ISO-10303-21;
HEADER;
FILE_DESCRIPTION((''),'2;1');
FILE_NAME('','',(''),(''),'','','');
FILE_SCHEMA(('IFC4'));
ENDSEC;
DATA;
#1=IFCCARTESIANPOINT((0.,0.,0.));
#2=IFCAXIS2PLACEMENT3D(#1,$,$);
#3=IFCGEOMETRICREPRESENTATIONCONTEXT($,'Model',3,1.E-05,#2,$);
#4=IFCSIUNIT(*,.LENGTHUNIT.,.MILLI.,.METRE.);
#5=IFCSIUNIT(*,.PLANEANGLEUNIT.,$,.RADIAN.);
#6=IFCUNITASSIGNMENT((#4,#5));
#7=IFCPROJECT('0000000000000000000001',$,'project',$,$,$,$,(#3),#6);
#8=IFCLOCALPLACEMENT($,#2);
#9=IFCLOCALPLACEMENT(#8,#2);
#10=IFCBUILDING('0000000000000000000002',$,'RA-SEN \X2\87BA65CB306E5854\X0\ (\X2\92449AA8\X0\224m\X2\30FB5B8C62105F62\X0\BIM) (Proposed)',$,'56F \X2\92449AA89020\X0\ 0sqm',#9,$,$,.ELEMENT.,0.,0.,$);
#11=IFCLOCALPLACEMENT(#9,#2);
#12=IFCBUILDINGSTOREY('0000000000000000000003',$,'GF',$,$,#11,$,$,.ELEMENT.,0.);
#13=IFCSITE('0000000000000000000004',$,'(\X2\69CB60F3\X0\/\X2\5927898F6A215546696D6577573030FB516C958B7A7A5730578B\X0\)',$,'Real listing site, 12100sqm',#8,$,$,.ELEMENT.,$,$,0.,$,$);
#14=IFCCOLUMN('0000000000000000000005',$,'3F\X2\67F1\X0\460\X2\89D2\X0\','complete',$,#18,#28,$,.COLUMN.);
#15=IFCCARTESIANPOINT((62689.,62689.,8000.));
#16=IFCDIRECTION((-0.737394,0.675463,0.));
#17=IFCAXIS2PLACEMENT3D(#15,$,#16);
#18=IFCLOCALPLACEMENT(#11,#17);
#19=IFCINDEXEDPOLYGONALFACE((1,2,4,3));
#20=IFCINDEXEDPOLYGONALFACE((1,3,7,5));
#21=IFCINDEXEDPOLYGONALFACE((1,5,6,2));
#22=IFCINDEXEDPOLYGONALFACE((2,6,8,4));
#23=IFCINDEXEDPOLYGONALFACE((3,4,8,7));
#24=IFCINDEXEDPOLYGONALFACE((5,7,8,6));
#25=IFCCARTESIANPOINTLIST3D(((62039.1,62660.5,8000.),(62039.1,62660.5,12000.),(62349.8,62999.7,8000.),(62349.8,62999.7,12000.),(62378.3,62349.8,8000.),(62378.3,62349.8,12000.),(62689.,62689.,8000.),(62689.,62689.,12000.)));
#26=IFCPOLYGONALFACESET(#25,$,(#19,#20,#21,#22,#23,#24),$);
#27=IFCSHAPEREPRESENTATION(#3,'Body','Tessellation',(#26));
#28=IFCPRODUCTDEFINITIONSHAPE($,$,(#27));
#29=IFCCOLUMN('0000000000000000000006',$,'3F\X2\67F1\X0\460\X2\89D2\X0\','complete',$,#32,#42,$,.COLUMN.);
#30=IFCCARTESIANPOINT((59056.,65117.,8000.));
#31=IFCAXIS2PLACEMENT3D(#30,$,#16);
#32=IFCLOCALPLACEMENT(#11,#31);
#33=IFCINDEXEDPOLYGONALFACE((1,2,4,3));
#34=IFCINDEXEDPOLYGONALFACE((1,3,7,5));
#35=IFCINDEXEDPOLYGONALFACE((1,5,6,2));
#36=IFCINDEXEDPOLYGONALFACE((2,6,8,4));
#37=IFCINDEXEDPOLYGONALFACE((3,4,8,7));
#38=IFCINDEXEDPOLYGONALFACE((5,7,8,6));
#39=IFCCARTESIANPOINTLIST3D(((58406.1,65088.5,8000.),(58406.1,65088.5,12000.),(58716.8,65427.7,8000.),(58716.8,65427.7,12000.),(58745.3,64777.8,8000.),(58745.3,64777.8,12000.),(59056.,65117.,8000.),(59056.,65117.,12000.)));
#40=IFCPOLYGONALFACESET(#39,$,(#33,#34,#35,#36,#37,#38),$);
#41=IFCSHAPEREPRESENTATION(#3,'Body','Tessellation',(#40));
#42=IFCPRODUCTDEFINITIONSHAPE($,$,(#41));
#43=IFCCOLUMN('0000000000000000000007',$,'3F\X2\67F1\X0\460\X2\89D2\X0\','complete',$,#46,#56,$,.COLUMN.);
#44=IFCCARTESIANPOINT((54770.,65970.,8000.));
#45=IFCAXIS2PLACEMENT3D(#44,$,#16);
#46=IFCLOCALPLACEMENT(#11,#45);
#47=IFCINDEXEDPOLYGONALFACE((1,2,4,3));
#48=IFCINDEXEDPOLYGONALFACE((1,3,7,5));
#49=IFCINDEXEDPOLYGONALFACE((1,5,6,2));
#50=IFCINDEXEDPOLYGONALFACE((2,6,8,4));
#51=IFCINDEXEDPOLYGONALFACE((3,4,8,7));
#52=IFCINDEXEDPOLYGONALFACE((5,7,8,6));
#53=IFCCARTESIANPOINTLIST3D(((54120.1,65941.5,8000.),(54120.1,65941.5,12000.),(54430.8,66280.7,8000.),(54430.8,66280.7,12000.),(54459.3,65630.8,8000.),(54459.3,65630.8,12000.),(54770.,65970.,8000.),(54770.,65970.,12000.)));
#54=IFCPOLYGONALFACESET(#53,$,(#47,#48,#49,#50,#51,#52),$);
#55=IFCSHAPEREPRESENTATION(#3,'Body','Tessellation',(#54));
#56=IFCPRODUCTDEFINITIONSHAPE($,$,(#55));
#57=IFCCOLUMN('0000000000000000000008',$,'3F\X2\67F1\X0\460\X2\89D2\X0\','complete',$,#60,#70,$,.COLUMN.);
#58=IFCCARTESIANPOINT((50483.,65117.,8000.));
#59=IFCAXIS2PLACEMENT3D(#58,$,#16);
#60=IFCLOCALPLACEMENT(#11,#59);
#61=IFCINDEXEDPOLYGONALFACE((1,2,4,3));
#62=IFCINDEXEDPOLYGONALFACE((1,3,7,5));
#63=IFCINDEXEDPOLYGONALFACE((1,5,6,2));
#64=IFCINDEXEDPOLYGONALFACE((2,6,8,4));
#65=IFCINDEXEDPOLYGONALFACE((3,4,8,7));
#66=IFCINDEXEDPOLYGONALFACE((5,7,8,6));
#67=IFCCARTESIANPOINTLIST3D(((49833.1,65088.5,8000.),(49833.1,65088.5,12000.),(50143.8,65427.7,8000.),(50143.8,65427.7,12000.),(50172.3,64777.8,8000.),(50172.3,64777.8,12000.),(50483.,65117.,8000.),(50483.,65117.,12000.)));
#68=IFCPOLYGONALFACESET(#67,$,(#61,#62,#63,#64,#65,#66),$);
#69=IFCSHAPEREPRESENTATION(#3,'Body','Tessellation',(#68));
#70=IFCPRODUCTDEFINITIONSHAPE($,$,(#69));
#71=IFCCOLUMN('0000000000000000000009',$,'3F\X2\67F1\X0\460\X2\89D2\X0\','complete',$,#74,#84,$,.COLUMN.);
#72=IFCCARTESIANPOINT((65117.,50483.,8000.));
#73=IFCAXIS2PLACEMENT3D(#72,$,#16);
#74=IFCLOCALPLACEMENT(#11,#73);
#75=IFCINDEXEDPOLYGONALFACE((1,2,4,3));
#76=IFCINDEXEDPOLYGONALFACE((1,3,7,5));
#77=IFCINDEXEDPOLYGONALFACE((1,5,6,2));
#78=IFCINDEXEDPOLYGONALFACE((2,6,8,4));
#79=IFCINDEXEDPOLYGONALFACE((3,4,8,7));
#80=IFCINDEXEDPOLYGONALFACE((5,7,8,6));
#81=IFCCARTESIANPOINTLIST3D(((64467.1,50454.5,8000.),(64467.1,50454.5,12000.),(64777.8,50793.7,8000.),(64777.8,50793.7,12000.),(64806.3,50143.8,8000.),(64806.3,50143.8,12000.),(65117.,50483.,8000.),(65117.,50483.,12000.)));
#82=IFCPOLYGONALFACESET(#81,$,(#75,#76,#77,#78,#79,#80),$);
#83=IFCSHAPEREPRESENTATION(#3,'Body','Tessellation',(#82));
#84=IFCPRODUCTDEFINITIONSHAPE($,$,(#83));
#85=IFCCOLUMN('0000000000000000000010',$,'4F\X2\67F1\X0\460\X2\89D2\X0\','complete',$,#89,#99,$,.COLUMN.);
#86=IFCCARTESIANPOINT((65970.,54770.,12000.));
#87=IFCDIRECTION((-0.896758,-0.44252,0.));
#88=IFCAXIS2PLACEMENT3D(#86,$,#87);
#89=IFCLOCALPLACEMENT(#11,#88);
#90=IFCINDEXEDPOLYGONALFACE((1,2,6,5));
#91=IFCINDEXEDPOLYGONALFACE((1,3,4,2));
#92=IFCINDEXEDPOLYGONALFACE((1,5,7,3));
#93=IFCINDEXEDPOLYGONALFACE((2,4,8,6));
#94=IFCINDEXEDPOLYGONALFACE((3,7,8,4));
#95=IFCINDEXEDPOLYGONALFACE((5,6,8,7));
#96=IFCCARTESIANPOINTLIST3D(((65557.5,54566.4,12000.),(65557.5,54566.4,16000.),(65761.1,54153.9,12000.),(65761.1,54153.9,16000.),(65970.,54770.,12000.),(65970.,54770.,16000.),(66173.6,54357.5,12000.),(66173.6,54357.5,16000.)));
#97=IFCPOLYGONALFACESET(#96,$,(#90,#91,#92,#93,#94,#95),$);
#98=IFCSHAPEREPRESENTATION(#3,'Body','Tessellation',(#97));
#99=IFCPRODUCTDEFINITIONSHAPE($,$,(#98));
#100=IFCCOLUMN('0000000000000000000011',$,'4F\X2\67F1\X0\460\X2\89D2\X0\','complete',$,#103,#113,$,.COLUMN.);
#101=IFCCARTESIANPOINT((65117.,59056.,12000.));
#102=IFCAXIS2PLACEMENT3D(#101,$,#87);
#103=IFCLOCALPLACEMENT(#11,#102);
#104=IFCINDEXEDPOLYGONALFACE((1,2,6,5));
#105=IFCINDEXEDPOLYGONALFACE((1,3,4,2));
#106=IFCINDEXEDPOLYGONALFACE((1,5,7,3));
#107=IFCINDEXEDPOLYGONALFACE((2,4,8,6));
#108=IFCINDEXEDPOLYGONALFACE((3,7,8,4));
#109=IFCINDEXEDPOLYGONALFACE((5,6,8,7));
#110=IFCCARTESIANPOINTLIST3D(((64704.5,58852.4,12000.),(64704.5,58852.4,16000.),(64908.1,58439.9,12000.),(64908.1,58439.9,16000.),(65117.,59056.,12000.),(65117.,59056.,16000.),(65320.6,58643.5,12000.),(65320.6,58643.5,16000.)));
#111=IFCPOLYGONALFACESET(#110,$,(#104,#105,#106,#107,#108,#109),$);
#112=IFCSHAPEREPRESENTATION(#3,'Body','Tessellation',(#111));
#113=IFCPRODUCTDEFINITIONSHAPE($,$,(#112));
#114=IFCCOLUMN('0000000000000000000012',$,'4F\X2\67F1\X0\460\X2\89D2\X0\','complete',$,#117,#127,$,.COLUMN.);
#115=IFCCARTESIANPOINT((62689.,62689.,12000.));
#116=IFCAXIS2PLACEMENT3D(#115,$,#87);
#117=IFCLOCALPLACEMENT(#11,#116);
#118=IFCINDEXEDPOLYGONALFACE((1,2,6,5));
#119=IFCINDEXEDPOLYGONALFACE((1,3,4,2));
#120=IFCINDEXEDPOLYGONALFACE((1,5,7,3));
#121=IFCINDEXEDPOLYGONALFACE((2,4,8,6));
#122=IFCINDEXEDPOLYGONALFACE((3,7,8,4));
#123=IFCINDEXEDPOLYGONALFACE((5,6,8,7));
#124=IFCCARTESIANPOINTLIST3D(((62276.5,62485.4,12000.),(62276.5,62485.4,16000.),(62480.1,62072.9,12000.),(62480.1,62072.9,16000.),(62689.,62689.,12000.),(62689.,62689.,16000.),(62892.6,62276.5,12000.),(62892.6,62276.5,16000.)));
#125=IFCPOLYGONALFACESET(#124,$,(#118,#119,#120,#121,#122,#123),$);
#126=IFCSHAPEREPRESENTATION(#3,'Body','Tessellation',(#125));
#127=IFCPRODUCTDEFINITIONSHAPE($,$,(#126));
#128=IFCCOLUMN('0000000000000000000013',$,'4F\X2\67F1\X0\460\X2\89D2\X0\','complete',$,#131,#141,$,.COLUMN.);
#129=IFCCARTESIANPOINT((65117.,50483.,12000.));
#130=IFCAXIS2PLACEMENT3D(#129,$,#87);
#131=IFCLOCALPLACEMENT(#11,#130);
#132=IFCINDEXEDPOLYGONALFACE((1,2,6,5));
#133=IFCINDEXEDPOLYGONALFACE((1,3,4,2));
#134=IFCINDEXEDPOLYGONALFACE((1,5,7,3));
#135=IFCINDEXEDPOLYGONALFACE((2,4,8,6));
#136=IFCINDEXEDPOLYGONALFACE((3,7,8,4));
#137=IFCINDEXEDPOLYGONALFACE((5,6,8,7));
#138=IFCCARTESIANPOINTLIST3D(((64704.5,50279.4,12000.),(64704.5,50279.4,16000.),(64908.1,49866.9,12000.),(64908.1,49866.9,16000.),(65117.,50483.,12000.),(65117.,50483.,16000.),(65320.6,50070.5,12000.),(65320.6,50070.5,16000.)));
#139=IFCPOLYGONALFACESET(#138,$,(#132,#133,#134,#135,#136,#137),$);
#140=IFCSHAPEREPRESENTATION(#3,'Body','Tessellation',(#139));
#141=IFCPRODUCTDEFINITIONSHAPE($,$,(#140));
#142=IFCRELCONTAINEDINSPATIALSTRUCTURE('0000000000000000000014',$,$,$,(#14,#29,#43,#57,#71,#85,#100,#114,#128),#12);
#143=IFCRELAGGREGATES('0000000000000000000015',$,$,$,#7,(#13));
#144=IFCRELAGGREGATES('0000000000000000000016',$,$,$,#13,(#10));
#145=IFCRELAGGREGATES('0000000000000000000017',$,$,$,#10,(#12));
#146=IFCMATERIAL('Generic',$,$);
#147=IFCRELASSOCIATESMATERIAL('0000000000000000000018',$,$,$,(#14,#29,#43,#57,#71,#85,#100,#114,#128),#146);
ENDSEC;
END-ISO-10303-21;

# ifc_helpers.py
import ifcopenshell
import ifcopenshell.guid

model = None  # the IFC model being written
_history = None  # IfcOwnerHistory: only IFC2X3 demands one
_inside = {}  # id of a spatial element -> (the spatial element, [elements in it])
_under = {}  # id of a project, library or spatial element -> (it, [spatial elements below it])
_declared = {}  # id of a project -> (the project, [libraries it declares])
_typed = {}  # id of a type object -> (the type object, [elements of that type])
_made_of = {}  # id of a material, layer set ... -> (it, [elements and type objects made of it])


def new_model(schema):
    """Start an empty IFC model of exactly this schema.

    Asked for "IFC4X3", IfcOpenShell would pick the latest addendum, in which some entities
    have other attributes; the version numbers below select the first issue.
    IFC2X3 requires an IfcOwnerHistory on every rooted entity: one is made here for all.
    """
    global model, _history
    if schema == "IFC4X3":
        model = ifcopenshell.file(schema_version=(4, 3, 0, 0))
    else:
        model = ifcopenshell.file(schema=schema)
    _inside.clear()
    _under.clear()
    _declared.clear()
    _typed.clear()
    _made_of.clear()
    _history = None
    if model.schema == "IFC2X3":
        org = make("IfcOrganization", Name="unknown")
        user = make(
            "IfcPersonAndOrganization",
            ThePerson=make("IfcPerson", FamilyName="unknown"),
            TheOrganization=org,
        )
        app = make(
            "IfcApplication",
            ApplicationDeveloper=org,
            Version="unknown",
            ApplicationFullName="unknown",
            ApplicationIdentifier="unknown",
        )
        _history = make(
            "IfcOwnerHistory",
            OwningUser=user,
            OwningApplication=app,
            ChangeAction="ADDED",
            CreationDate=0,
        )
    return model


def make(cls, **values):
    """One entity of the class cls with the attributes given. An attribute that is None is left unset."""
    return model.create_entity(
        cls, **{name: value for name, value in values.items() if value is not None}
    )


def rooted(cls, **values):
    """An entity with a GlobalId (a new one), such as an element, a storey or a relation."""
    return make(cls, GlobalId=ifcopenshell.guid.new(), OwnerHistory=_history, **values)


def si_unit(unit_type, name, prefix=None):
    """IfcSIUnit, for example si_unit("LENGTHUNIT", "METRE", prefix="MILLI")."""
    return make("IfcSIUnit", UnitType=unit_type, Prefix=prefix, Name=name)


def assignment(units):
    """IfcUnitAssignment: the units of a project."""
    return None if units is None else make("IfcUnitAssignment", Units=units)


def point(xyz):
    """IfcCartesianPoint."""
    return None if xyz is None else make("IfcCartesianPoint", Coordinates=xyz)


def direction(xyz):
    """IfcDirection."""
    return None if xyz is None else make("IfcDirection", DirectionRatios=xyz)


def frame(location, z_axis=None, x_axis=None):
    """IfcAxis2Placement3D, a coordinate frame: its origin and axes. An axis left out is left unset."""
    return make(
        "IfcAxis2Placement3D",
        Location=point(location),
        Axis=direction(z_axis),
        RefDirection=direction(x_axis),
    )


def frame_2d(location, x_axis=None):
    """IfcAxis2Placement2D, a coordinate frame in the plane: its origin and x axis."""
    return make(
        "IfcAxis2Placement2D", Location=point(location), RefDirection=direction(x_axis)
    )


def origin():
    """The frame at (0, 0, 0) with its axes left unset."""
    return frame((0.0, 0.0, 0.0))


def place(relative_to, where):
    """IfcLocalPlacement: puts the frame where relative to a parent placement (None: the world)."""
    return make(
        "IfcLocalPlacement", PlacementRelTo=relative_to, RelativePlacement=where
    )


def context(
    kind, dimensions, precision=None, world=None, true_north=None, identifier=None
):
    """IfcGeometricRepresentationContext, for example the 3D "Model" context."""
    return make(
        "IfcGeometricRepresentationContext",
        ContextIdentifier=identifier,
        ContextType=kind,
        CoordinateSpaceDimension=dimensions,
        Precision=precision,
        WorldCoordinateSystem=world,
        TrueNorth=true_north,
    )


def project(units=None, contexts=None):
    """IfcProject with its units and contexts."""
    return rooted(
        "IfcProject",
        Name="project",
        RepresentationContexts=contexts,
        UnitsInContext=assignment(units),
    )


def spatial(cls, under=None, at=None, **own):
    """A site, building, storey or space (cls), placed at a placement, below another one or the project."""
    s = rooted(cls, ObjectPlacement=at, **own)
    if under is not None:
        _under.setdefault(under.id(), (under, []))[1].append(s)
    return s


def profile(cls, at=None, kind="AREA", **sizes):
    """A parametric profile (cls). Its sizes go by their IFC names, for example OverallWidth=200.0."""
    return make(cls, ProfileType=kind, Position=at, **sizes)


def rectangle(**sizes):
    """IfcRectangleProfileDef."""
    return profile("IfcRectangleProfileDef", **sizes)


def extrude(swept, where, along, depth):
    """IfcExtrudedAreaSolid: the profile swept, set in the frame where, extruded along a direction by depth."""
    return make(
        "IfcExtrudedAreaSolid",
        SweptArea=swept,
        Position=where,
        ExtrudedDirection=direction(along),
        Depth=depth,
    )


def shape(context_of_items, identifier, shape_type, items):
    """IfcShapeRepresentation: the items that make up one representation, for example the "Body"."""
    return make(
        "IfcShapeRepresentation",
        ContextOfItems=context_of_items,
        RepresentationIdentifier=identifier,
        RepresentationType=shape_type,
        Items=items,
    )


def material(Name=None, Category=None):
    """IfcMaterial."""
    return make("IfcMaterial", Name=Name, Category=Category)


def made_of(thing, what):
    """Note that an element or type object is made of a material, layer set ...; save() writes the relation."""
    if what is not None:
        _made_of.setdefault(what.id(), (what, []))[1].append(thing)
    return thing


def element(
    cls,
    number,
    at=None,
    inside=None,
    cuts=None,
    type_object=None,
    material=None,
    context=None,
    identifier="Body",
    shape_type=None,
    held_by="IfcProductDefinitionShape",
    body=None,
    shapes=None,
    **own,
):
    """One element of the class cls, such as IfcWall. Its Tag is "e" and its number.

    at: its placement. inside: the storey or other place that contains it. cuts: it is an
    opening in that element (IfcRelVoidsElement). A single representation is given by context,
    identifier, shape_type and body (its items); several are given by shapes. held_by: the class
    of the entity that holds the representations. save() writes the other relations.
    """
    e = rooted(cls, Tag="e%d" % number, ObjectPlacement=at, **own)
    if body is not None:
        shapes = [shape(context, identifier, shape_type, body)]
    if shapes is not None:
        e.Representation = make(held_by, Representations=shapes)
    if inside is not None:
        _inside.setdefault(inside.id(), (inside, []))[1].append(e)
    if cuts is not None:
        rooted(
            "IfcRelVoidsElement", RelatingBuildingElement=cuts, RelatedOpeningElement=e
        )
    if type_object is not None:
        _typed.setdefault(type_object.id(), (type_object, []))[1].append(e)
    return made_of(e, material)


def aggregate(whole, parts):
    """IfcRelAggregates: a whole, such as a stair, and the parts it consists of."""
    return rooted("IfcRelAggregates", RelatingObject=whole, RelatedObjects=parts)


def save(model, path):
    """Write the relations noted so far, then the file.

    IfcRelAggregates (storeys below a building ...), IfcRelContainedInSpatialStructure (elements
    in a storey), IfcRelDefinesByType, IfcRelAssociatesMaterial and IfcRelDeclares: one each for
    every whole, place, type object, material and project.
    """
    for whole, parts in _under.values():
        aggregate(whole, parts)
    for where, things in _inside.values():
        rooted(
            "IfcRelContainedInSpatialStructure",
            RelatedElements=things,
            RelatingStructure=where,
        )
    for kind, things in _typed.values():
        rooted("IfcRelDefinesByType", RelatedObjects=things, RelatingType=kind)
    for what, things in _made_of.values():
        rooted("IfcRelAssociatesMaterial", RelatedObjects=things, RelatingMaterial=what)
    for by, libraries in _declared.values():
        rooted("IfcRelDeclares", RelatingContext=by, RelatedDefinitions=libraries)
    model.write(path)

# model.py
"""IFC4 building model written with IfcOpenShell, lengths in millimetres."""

from ifc_helpers import new_model, si_unit, frame, frame_2d, origin, place, context, project, spatial, rectangle, extrude, material, element, save


model = new_model("IFC4")

# Units and contexts
model_context = context("Model", 3, precision=1e-05, world=origin())
ifc_project = project(units=[si_unit("LENGTHUNIT", "METRE", prefix="MILLI"), si_unit("PLANEANGLEUNIT", "RADIAN")], contexts=[model_context])

# Site, building, storey
site_placement = place(None, origin())
site = spatial("IfcSite", under=ifc_project, at=site_placement, Name="(構想/大規模商業敷地・公開空地型)", ObjectType="Real listing site, 12100sqm", CompositionType="ELEMENT", RefElevation=0.0)
building_placement = place(site_placement, origin())
building = spatial("IfcBuilding", under=site, at=building_placement, Name="RA-SEN 螺旋の塔 (鉄骨224m・完成形BIM) (Proposed)", ObjectType="56F 鉄骨造 0sqm", CompositionType="ELEMENT", ElevationOfRefHeight=0.0, ElevationOfTerrain=0.0)
storey_placement = place(building_placement, origin())
storey = spatial("IfcBuildingStorey", under=building, at=storey_placement, Name="GF", CompositionType="ELEMENT", Elevation=0.0)

# Columns
ifc_material = material(Name="Generic")
column_1_placement = place(storey_placement, frame((62689.0, 62689.0, 8000.0), x_axis=(-0.737394, 0.675463, 0.0)))
element("IfcColumn", 1, at=column_1_placement, inside=storey, material=ifc_material, Name="3F柱460角", Description="complete", PredefinedType="COLUMN", context=model_context, shape_type="SweptSolid", body=[
    extrude(rectangle(XDim=460.0, YDim=460.0, at=frame_2d((230.0, 230.0))), frame((62689.0, 62689.0, 8000.0), x_axis=(-0.737394, 0.675463, 0.0)), (0.0, 0.0, 1.0), 4000.0),
])
column_2_placement = place(storey_placement, frame((59056.0, 65117.0, 8000.0), x_axis=(-0.737394, 0.675463, 0.0)))
element("IfcColumn", 2, at=column_2_placement, inside=storey, material=ifc_material, Name="3F柱460角", Description="complete", PredefinedType="COLUMN", context=model_context, shape_type="SweptSolid", body=[
    extrude(rectangle(XDim=460.0, YDim=460.0, at=frame_2d((230.0, 230.0))), frame((59056.0, 65117.0, 8000.0), x_axis=(-0.737394, 0.675463, 0.0)), (0.0, 0.0, 1.0), 4000.0),
])
column_3_placement = place(storey_placement, frame((54770.0, 65970.0, 8000.0), x_axis=(-0.737394, 0.675463, 0.0)))
element("IfcColumn", 3, at=column_3_placement, inside=storey, material=ifc_material, Name="3F柱460角", Description="complete", PredefinedType="COLUMN", context=model_context, shape_type="SweptSolid", body=[
    extrude(rectangle(XDim=460.0, YDim=460.0, at=frame_2d((230.0, 230.0))), frame((54770.0, 65970.0, 8000.0), x_axis=(-0.737394, 0.675463, 0.0)), (0.0, 0.0, 1.0), 4000.0),
])
column_4_placement = place(storey_placement, frame((50483.0, 65117.0, 8000.0), x_axis=(-0.737394, 0.675463, 0.0)))
element("IfcColumn", 4, at=column_4_placement, inside=storey, material=ifc_material, Name="3F柱460角", Description="complete", PredefinedType="COLUMN", context=model_context, shape_type="SweptSolid", body=[
    extrude(rectangle(XDim=460.0, YDim=460.0, at=frame_2d((230.0, 230.0))), frame((50483.0, 65117.0, 8000.0), x_axis=(-0.737394, 0.675463, 0.0)), (0.0, 0.0, 1.0), 4000.0),
])
column_5_placement = place(storey_placement, frame((65117.0, 50483.0, 8000.0), x_axis=(-0.737394, 0.675463, 0.0)))
element("IfcColumn", 5, at=column_5_placement, inside=storey, material=ifc_material, Name="3F柱460角", Description="complete", PredefinedType="COLUMN", context=model_context, shape_type="SweptSolid", body=[
    extrude(rectangle(XDim=460.0, YDim=460.0, at=frame_2d((230.0, 230.0))), frame((65117.0, 50483.0, 8000.0), x_axis=(-0.737394, 0.675463, 0.0)), (0.0, 0.0, 1.0), 4000.0),
])
column_6_placement = place(storey_placement, frame((65970.0, 54770.0, 12000.0), x_axis=(-0.896758, -0.44252, 0.0)))
element("IfcColumn", 6, at=column_6_placement, inside=storey, material=ifc_material, Name="4F柱460角", Description="complete", PredefinedType="COLUMN", context=model_context, shape_type="SweptSolid", body=[
    extrude(rectangle(XDim=460.0, YDim=460.0, at=frame_2d((230.0, 230.0))), frame((65970.0, 54770.0, 12000.0), x_axis=(-0.896758, -0.44252, 0.0)), (0.0, 0.0, 1.0), 4000.0),
])
column_7_placement = place(storey_placement, frame((65117.0, 59056.0, 12000.0), x_axis=(-0.896758, -0.44252, 0.0)))
element("IfcColumn", 7, at=column_7_placement, inside=storey, material=ifc_material, Name="4F柱460角", Description="complete", PredefinedType="COLUMN", context=model_context, shape_type="SweptSolid", body=[
    extrude(rectangle(XDim=460.0, YDim=460.0, at=frame_2d((230.0, 230.0))), frame((65117.0, 59056.0, 12000.0), x_axis=(-0.896758, -0.44252, 0.0)), (0.0, 0.0, 1.0), 4000.0),
])
column_8_placement = place(storey_placement, frame((62689.0, 62689.0, 12000.0), x_axis=(-0.896758, -0.44252, 0.0)))
element("IfcColumn", 8, at=column_8_placement, inside=storey, material=ifc_material, Name="4F柱460角", Description="complete", PredefinedType="COLUMN", context=model_context, shape_type="SweptSolid", body=[
    extrude(rectangle(XDim=460.0, YDim=460.0, at=frame_2d((230.0, 230.0))), frame((62689.0, 62689.0, 12000.0), x_axis=(-0.896758, -0.44252, 0.0)), (0.0, 0.0, 1.0), 4000.0),
])
column_9_placement = place(storey_placement, frame((65117.0, 50483.0, 12000.0), x_axis=(-0.896758, -0.44252, 0.0)))
element("IfcColumn", 9, at=column_9_placement, inside=storey, material=ifc_material, Name="4F柱460角", Description="complete", PredefinedType="COLUMN", context=model_context, shape_type="SweptSolid", body=[
    extrude(rectangle(XDim=460.0, YDim=460.0, at=frame_2d((230.0, 230.0))), frame((65117.0, 50483.0, 12000.0), x_axis=(-0.896758, -0.44252, 0.0)), (0.0, 0.0, 1.0), 4000.0),
])

save(model, "model.ifc")
